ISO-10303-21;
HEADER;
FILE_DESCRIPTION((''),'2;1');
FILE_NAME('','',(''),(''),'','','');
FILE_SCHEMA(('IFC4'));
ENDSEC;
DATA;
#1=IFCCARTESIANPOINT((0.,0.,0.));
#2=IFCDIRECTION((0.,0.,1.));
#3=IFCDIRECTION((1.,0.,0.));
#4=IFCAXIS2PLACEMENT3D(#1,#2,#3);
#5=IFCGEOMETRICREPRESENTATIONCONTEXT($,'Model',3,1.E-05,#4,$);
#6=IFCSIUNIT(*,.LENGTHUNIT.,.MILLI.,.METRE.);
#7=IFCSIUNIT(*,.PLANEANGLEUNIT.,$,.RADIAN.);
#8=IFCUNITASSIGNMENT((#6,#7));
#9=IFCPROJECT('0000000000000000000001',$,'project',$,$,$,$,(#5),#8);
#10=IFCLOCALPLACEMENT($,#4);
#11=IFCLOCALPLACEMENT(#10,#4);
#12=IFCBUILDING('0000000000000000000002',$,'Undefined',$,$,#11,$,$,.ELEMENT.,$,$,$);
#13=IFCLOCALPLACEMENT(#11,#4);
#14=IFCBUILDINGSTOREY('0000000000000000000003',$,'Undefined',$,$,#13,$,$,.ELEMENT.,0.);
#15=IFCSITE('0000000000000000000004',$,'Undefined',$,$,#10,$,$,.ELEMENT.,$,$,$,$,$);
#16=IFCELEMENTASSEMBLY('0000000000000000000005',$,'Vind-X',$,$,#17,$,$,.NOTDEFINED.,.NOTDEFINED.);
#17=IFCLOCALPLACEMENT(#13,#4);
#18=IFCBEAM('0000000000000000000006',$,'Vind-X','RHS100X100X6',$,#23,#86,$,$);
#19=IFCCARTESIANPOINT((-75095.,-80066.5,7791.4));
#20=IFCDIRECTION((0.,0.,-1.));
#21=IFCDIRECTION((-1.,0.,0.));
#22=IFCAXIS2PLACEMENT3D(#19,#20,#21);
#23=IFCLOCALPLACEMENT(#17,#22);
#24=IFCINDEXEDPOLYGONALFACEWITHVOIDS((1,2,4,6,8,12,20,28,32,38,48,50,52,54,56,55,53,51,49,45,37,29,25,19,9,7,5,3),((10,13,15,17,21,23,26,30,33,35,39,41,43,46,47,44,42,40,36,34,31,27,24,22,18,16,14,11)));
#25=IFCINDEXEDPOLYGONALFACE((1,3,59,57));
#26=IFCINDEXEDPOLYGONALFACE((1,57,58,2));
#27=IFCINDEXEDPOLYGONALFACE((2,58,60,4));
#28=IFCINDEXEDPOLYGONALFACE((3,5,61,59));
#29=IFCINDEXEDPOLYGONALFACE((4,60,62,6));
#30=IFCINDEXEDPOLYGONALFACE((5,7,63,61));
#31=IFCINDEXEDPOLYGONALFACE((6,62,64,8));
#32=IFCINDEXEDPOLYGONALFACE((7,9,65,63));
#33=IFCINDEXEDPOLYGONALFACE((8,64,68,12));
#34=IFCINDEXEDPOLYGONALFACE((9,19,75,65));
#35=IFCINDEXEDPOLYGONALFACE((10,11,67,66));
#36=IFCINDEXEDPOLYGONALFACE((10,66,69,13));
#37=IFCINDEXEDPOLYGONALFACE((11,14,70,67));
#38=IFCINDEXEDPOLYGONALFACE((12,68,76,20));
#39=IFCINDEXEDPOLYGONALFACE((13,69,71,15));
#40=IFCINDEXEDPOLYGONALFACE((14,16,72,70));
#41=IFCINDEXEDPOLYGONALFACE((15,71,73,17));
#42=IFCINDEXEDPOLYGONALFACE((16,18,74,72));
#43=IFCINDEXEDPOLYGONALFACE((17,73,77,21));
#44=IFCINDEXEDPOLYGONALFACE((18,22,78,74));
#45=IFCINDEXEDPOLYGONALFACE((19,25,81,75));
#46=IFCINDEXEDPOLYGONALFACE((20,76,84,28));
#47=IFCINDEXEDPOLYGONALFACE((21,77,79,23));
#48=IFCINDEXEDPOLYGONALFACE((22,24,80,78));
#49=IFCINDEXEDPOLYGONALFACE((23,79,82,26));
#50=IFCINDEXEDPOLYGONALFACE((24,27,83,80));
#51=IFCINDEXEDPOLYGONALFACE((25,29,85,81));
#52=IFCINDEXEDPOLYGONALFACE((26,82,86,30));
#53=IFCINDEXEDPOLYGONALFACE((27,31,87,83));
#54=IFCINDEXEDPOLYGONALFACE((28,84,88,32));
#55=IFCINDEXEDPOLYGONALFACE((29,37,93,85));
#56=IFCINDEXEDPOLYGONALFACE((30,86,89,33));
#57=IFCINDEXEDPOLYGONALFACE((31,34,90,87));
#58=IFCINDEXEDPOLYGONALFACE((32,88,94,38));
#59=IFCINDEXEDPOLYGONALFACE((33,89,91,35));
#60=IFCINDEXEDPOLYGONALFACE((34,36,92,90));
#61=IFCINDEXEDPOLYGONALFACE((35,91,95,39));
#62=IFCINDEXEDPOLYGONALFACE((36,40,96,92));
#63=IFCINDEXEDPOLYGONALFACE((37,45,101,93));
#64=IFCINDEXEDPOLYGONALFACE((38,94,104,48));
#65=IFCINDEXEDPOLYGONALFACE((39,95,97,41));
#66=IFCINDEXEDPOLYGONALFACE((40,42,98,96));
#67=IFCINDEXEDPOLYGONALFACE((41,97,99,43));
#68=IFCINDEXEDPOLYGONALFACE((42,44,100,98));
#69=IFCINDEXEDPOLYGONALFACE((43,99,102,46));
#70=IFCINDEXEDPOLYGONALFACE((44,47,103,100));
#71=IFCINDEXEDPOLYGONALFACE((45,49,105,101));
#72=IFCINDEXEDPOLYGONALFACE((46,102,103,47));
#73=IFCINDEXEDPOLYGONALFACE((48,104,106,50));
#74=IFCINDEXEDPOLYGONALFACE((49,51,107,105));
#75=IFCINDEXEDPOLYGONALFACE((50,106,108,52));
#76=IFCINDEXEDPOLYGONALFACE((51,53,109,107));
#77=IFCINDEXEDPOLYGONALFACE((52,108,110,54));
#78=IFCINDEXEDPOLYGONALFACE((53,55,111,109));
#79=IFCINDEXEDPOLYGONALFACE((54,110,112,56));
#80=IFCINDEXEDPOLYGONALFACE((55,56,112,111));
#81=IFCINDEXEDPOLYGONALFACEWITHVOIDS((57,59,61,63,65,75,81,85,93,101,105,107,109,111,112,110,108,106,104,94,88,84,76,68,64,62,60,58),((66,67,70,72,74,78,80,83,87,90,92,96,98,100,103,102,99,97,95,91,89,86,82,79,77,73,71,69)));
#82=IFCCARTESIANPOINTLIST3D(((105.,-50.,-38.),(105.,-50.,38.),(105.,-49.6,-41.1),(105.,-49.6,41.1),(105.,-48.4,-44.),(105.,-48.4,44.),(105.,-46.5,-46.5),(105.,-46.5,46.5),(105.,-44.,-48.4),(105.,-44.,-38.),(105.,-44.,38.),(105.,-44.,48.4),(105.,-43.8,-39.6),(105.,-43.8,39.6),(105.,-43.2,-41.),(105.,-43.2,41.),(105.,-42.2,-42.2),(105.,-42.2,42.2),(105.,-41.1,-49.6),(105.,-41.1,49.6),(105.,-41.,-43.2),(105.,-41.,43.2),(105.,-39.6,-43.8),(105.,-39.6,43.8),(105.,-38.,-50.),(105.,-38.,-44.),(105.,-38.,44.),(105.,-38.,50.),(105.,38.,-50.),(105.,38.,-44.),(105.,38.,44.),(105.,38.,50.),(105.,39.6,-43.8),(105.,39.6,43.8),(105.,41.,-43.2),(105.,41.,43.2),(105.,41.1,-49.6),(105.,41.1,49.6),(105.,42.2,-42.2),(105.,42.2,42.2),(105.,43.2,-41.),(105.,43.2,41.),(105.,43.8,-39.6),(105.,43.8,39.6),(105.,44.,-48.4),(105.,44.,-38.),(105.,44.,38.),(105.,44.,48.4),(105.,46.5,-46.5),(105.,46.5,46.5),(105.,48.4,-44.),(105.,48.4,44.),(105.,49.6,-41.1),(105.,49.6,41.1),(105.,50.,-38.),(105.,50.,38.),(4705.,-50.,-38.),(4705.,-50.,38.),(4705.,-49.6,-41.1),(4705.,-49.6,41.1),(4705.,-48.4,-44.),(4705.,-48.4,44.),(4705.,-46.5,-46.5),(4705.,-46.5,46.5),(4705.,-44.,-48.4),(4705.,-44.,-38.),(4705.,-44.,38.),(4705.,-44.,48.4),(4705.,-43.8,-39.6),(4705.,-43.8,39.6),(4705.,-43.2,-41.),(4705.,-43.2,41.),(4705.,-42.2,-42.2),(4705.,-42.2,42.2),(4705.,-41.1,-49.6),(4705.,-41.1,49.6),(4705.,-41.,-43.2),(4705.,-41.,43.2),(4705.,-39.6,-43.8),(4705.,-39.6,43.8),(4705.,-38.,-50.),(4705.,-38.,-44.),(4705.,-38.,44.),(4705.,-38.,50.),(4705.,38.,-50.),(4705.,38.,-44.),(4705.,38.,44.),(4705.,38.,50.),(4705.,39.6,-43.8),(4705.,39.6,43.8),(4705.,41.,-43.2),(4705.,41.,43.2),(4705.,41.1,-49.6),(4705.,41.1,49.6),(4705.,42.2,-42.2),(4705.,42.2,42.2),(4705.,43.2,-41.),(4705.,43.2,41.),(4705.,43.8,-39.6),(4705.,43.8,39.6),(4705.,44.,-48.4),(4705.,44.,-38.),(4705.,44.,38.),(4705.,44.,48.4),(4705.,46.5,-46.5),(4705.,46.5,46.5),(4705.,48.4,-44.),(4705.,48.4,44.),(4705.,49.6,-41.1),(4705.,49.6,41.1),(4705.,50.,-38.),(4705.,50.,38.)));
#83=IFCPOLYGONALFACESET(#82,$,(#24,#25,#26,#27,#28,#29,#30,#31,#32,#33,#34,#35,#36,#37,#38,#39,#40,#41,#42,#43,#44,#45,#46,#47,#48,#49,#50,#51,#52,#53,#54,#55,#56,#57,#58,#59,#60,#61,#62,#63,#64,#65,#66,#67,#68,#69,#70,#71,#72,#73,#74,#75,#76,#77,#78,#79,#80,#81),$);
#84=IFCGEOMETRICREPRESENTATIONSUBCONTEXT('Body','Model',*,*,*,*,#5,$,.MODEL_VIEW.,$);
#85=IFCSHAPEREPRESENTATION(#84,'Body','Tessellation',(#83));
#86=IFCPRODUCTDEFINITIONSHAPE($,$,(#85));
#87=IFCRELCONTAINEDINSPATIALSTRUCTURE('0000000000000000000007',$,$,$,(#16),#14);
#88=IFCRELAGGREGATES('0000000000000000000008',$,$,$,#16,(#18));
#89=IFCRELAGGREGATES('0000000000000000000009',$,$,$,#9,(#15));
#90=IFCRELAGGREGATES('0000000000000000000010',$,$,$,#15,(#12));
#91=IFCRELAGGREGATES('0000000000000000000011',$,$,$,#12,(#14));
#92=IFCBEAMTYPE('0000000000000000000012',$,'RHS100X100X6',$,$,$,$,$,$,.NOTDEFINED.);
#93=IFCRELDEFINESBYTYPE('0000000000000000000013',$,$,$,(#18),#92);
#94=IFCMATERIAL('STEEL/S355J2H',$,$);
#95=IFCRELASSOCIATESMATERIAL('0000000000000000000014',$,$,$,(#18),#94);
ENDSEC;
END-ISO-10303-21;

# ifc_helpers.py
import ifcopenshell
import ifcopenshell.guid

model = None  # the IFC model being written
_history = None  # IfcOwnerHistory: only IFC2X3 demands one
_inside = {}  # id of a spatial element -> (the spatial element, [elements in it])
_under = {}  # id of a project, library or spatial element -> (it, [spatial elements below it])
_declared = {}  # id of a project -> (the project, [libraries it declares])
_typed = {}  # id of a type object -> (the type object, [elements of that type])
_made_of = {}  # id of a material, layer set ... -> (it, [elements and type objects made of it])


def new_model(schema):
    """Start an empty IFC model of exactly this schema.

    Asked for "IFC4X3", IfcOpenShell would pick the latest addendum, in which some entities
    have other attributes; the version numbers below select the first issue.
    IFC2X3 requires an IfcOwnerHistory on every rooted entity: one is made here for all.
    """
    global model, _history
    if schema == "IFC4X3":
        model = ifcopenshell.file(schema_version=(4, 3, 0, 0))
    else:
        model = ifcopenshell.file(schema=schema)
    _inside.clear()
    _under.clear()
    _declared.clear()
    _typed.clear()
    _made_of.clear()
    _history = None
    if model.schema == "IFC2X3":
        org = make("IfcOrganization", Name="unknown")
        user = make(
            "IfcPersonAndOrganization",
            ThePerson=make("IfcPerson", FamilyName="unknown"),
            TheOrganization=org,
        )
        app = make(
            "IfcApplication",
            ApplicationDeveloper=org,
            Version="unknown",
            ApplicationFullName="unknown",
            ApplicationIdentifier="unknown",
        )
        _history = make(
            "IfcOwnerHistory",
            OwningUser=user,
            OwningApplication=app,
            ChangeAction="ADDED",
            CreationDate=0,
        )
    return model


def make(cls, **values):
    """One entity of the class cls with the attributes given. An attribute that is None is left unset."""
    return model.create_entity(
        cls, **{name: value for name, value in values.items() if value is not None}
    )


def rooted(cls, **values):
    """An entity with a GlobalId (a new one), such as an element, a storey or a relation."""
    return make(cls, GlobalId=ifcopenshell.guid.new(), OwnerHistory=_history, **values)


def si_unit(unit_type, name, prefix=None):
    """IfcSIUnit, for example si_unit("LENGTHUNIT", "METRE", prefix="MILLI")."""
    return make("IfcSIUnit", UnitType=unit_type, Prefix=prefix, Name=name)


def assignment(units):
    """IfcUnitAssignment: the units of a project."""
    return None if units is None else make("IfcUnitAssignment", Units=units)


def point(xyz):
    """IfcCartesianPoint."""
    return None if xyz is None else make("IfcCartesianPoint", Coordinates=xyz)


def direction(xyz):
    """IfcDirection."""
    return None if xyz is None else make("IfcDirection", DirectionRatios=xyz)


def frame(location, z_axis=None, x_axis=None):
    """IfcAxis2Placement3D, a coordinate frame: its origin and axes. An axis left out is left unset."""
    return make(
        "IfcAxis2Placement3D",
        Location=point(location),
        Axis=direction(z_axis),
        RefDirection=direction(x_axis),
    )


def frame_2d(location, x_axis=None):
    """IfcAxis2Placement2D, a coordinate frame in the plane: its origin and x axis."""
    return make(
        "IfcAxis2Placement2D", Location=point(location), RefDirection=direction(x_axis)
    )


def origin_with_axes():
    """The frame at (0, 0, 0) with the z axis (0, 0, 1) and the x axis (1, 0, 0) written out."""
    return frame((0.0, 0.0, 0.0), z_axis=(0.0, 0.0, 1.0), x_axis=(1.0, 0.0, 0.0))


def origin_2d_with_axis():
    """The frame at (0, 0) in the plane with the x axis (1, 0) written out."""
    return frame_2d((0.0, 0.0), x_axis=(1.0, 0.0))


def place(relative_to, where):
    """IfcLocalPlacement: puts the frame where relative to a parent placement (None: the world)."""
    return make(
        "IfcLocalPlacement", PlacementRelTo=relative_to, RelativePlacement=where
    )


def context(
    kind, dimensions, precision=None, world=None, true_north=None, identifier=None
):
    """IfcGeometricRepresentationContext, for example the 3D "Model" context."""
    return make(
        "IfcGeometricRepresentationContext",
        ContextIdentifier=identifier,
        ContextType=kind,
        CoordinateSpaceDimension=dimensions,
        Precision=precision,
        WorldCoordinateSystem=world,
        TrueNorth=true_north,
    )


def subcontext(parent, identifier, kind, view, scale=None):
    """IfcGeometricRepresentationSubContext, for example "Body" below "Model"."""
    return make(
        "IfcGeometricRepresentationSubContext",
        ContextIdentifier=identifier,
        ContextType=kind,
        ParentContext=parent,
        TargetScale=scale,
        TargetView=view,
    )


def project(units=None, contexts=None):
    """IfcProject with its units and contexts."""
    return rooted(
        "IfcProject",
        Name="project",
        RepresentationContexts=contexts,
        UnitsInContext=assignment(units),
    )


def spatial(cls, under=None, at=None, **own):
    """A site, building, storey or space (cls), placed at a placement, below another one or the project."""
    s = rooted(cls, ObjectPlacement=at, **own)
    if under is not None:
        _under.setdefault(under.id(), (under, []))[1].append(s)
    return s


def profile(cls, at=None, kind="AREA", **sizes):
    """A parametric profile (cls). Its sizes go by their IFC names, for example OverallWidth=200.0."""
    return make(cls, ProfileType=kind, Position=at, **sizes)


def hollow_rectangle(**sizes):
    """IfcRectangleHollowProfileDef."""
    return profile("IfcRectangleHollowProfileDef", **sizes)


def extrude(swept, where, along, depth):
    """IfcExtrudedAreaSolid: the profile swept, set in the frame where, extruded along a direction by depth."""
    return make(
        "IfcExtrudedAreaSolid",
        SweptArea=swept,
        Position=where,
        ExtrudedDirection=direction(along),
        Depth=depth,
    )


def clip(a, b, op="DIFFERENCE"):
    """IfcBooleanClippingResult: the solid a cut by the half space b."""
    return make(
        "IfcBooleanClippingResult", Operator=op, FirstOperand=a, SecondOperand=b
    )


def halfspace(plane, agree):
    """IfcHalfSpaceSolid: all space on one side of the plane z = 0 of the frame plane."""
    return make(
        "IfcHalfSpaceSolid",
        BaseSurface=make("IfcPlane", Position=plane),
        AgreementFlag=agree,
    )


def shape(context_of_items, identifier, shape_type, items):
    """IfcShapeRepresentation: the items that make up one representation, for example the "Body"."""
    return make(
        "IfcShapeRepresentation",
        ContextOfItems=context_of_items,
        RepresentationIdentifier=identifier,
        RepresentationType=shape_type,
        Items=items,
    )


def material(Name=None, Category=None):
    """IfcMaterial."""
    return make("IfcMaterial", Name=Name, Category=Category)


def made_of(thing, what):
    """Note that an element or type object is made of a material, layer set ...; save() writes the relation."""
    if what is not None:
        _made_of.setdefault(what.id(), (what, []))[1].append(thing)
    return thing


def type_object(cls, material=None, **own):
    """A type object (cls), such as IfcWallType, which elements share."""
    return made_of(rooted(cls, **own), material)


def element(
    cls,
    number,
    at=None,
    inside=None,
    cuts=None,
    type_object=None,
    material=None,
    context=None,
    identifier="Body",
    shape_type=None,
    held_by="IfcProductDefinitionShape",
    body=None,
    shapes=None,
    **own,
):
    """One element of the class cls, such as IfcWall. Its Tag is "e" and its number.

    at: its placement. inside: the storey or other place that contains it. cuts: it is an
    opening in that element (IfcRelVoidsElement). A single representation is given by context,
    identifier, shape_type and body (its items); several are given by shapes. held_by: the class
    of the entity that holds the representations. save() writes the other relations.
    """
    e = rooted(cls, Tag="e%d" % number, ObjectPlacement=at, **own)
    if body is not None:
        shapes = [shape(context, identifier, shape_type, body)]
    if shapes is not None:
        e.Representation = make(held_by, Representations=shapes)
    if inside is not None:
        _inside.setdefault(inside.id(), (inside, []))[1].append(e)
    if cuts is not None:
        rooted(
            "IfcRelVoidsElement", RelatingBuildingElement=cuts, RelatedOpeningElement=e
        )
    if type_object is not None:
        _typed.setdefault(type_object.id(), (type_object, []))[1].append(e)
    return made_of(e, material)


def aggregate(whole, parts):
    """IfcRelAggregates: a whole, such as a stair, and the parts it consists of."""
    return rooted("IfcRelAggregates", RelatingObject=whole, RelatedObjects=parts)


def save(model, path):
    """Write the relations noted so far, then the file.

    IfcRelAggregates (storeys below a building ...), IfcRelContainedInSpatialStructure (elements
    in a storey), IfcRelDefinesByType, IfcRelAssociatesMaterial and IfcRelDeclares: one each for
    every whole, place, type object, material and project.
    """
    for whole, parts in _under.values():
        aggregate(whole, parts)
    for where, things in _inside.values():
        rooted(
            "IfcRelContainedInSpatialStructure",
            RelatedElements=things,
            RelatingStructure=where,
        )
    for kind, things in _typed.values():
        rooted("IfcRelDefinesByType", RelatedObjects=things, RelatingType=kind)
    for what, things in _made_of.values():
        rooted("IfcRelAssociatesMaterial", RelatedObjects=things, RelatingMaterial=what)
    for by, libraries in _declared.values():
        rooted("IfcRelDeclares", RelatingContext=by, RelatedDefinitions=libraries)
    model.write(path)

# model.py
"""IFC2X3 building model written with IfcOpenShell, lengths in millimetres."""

from ifc_helpers import new_model, si_unit, frame, origin_with_axes, origin_2d_with_axis, place, context, subcontext, project, spatial, hollow_rectangle, extrude, clip, halfspace, material, type_object, element, aggregate, save


model = new_model("IFC2X3")

# Units and contexts
model_context = context("Model", 3, precision=1e-05, world=origin_with_axes())
body_context = subcontext(model_context, "Body", "Model", "MODEL_VIEW")
ifc_project = project(units=[si_unit("LENGTHUNIT", "METRE", prefix="MILLI"), si_unit("PLANEANGLEUNIT", "RADIAN")], contexts=[model_context])

# Site, building, storey
site_placement = place(None, origin_with_axes())
site = spatial("IfcSite", under=ifc_project, at=site_placement, Name="Undefined", CompositionType="ELEMENT")
building_placement = place(site_placement, origin_with_axes())
building = spatial("IfcBuilding", under=site, at=building_placement, Name="Undefined", CompositionType="ELEMENT")
storey_placement = place(building_placement, origin_with_axes())
storey = spatial("IfcBuildingStorey", under=building, at=storey_placement, Name="Undefined", CompositionType="ELEMENT", Elevation=0.0)

# Element assembly, beam
assembly_1_placement = place(storey_placement, origin_with_axes())
assembly_1 = element("IfcElementAssembly", 1, at=assembly_1_placement, inside=storey, Name="Vind-X", AssemblyPlace="NOTDEFINED", PredefinedType="NOTDEFINED")
ifc_material_1 = material(Name="STEEL/S355J2H")
beam_type_1 = type_object("IfcBeamType", Name="RHS100X100X6", PredefinedType="NOTDEFINED")
beam_1_placement = place(assembly_1_placement, frame((-75095.0, -80066.5, 7791.4), z_axis=(0.0, 0.0, -1.0), x_axis=(-1.0, 0.0, 0.0)))
beam_1 = element("IfcBeam", 2, at=beam_1_placement, type_object=beam_type_1, material=ifc_material_1, Name="Vind-X", Description="RHS100X100X6", context=body_context, shape_type="Clipping", body=[
    clip(clip(extrude(hollow_rectangle(XDim=100.0, YDim=100.0, WallThickness=6.0, InnerFilletRadius=6.0, OuterFilletRadius=12.0, at=origin_2d_with_axis()), frame((4810.0, 0.0, 0.0), z_axis=(-1.0, 0.0, 0.0), x_axis=(0.0, -1.0, 0.0)), (0.0, 0.0, 1.0), 4810.0), halfspace(frame((4705.0, 0.0, 0.0), z_axis=(-1.0, 0.0, 0.0), x_axis=(0.0, 1.0, 0.0)), True)), halfspace(frame((105.0, 0.0, 0.0), z_axis=(1.0, 0.0, 0.0), x_axis=(0.0, -1.0, 0.0)), True)),
])

aggregate(assembly_1, [beam_1])

save(model, "model.ifc")
